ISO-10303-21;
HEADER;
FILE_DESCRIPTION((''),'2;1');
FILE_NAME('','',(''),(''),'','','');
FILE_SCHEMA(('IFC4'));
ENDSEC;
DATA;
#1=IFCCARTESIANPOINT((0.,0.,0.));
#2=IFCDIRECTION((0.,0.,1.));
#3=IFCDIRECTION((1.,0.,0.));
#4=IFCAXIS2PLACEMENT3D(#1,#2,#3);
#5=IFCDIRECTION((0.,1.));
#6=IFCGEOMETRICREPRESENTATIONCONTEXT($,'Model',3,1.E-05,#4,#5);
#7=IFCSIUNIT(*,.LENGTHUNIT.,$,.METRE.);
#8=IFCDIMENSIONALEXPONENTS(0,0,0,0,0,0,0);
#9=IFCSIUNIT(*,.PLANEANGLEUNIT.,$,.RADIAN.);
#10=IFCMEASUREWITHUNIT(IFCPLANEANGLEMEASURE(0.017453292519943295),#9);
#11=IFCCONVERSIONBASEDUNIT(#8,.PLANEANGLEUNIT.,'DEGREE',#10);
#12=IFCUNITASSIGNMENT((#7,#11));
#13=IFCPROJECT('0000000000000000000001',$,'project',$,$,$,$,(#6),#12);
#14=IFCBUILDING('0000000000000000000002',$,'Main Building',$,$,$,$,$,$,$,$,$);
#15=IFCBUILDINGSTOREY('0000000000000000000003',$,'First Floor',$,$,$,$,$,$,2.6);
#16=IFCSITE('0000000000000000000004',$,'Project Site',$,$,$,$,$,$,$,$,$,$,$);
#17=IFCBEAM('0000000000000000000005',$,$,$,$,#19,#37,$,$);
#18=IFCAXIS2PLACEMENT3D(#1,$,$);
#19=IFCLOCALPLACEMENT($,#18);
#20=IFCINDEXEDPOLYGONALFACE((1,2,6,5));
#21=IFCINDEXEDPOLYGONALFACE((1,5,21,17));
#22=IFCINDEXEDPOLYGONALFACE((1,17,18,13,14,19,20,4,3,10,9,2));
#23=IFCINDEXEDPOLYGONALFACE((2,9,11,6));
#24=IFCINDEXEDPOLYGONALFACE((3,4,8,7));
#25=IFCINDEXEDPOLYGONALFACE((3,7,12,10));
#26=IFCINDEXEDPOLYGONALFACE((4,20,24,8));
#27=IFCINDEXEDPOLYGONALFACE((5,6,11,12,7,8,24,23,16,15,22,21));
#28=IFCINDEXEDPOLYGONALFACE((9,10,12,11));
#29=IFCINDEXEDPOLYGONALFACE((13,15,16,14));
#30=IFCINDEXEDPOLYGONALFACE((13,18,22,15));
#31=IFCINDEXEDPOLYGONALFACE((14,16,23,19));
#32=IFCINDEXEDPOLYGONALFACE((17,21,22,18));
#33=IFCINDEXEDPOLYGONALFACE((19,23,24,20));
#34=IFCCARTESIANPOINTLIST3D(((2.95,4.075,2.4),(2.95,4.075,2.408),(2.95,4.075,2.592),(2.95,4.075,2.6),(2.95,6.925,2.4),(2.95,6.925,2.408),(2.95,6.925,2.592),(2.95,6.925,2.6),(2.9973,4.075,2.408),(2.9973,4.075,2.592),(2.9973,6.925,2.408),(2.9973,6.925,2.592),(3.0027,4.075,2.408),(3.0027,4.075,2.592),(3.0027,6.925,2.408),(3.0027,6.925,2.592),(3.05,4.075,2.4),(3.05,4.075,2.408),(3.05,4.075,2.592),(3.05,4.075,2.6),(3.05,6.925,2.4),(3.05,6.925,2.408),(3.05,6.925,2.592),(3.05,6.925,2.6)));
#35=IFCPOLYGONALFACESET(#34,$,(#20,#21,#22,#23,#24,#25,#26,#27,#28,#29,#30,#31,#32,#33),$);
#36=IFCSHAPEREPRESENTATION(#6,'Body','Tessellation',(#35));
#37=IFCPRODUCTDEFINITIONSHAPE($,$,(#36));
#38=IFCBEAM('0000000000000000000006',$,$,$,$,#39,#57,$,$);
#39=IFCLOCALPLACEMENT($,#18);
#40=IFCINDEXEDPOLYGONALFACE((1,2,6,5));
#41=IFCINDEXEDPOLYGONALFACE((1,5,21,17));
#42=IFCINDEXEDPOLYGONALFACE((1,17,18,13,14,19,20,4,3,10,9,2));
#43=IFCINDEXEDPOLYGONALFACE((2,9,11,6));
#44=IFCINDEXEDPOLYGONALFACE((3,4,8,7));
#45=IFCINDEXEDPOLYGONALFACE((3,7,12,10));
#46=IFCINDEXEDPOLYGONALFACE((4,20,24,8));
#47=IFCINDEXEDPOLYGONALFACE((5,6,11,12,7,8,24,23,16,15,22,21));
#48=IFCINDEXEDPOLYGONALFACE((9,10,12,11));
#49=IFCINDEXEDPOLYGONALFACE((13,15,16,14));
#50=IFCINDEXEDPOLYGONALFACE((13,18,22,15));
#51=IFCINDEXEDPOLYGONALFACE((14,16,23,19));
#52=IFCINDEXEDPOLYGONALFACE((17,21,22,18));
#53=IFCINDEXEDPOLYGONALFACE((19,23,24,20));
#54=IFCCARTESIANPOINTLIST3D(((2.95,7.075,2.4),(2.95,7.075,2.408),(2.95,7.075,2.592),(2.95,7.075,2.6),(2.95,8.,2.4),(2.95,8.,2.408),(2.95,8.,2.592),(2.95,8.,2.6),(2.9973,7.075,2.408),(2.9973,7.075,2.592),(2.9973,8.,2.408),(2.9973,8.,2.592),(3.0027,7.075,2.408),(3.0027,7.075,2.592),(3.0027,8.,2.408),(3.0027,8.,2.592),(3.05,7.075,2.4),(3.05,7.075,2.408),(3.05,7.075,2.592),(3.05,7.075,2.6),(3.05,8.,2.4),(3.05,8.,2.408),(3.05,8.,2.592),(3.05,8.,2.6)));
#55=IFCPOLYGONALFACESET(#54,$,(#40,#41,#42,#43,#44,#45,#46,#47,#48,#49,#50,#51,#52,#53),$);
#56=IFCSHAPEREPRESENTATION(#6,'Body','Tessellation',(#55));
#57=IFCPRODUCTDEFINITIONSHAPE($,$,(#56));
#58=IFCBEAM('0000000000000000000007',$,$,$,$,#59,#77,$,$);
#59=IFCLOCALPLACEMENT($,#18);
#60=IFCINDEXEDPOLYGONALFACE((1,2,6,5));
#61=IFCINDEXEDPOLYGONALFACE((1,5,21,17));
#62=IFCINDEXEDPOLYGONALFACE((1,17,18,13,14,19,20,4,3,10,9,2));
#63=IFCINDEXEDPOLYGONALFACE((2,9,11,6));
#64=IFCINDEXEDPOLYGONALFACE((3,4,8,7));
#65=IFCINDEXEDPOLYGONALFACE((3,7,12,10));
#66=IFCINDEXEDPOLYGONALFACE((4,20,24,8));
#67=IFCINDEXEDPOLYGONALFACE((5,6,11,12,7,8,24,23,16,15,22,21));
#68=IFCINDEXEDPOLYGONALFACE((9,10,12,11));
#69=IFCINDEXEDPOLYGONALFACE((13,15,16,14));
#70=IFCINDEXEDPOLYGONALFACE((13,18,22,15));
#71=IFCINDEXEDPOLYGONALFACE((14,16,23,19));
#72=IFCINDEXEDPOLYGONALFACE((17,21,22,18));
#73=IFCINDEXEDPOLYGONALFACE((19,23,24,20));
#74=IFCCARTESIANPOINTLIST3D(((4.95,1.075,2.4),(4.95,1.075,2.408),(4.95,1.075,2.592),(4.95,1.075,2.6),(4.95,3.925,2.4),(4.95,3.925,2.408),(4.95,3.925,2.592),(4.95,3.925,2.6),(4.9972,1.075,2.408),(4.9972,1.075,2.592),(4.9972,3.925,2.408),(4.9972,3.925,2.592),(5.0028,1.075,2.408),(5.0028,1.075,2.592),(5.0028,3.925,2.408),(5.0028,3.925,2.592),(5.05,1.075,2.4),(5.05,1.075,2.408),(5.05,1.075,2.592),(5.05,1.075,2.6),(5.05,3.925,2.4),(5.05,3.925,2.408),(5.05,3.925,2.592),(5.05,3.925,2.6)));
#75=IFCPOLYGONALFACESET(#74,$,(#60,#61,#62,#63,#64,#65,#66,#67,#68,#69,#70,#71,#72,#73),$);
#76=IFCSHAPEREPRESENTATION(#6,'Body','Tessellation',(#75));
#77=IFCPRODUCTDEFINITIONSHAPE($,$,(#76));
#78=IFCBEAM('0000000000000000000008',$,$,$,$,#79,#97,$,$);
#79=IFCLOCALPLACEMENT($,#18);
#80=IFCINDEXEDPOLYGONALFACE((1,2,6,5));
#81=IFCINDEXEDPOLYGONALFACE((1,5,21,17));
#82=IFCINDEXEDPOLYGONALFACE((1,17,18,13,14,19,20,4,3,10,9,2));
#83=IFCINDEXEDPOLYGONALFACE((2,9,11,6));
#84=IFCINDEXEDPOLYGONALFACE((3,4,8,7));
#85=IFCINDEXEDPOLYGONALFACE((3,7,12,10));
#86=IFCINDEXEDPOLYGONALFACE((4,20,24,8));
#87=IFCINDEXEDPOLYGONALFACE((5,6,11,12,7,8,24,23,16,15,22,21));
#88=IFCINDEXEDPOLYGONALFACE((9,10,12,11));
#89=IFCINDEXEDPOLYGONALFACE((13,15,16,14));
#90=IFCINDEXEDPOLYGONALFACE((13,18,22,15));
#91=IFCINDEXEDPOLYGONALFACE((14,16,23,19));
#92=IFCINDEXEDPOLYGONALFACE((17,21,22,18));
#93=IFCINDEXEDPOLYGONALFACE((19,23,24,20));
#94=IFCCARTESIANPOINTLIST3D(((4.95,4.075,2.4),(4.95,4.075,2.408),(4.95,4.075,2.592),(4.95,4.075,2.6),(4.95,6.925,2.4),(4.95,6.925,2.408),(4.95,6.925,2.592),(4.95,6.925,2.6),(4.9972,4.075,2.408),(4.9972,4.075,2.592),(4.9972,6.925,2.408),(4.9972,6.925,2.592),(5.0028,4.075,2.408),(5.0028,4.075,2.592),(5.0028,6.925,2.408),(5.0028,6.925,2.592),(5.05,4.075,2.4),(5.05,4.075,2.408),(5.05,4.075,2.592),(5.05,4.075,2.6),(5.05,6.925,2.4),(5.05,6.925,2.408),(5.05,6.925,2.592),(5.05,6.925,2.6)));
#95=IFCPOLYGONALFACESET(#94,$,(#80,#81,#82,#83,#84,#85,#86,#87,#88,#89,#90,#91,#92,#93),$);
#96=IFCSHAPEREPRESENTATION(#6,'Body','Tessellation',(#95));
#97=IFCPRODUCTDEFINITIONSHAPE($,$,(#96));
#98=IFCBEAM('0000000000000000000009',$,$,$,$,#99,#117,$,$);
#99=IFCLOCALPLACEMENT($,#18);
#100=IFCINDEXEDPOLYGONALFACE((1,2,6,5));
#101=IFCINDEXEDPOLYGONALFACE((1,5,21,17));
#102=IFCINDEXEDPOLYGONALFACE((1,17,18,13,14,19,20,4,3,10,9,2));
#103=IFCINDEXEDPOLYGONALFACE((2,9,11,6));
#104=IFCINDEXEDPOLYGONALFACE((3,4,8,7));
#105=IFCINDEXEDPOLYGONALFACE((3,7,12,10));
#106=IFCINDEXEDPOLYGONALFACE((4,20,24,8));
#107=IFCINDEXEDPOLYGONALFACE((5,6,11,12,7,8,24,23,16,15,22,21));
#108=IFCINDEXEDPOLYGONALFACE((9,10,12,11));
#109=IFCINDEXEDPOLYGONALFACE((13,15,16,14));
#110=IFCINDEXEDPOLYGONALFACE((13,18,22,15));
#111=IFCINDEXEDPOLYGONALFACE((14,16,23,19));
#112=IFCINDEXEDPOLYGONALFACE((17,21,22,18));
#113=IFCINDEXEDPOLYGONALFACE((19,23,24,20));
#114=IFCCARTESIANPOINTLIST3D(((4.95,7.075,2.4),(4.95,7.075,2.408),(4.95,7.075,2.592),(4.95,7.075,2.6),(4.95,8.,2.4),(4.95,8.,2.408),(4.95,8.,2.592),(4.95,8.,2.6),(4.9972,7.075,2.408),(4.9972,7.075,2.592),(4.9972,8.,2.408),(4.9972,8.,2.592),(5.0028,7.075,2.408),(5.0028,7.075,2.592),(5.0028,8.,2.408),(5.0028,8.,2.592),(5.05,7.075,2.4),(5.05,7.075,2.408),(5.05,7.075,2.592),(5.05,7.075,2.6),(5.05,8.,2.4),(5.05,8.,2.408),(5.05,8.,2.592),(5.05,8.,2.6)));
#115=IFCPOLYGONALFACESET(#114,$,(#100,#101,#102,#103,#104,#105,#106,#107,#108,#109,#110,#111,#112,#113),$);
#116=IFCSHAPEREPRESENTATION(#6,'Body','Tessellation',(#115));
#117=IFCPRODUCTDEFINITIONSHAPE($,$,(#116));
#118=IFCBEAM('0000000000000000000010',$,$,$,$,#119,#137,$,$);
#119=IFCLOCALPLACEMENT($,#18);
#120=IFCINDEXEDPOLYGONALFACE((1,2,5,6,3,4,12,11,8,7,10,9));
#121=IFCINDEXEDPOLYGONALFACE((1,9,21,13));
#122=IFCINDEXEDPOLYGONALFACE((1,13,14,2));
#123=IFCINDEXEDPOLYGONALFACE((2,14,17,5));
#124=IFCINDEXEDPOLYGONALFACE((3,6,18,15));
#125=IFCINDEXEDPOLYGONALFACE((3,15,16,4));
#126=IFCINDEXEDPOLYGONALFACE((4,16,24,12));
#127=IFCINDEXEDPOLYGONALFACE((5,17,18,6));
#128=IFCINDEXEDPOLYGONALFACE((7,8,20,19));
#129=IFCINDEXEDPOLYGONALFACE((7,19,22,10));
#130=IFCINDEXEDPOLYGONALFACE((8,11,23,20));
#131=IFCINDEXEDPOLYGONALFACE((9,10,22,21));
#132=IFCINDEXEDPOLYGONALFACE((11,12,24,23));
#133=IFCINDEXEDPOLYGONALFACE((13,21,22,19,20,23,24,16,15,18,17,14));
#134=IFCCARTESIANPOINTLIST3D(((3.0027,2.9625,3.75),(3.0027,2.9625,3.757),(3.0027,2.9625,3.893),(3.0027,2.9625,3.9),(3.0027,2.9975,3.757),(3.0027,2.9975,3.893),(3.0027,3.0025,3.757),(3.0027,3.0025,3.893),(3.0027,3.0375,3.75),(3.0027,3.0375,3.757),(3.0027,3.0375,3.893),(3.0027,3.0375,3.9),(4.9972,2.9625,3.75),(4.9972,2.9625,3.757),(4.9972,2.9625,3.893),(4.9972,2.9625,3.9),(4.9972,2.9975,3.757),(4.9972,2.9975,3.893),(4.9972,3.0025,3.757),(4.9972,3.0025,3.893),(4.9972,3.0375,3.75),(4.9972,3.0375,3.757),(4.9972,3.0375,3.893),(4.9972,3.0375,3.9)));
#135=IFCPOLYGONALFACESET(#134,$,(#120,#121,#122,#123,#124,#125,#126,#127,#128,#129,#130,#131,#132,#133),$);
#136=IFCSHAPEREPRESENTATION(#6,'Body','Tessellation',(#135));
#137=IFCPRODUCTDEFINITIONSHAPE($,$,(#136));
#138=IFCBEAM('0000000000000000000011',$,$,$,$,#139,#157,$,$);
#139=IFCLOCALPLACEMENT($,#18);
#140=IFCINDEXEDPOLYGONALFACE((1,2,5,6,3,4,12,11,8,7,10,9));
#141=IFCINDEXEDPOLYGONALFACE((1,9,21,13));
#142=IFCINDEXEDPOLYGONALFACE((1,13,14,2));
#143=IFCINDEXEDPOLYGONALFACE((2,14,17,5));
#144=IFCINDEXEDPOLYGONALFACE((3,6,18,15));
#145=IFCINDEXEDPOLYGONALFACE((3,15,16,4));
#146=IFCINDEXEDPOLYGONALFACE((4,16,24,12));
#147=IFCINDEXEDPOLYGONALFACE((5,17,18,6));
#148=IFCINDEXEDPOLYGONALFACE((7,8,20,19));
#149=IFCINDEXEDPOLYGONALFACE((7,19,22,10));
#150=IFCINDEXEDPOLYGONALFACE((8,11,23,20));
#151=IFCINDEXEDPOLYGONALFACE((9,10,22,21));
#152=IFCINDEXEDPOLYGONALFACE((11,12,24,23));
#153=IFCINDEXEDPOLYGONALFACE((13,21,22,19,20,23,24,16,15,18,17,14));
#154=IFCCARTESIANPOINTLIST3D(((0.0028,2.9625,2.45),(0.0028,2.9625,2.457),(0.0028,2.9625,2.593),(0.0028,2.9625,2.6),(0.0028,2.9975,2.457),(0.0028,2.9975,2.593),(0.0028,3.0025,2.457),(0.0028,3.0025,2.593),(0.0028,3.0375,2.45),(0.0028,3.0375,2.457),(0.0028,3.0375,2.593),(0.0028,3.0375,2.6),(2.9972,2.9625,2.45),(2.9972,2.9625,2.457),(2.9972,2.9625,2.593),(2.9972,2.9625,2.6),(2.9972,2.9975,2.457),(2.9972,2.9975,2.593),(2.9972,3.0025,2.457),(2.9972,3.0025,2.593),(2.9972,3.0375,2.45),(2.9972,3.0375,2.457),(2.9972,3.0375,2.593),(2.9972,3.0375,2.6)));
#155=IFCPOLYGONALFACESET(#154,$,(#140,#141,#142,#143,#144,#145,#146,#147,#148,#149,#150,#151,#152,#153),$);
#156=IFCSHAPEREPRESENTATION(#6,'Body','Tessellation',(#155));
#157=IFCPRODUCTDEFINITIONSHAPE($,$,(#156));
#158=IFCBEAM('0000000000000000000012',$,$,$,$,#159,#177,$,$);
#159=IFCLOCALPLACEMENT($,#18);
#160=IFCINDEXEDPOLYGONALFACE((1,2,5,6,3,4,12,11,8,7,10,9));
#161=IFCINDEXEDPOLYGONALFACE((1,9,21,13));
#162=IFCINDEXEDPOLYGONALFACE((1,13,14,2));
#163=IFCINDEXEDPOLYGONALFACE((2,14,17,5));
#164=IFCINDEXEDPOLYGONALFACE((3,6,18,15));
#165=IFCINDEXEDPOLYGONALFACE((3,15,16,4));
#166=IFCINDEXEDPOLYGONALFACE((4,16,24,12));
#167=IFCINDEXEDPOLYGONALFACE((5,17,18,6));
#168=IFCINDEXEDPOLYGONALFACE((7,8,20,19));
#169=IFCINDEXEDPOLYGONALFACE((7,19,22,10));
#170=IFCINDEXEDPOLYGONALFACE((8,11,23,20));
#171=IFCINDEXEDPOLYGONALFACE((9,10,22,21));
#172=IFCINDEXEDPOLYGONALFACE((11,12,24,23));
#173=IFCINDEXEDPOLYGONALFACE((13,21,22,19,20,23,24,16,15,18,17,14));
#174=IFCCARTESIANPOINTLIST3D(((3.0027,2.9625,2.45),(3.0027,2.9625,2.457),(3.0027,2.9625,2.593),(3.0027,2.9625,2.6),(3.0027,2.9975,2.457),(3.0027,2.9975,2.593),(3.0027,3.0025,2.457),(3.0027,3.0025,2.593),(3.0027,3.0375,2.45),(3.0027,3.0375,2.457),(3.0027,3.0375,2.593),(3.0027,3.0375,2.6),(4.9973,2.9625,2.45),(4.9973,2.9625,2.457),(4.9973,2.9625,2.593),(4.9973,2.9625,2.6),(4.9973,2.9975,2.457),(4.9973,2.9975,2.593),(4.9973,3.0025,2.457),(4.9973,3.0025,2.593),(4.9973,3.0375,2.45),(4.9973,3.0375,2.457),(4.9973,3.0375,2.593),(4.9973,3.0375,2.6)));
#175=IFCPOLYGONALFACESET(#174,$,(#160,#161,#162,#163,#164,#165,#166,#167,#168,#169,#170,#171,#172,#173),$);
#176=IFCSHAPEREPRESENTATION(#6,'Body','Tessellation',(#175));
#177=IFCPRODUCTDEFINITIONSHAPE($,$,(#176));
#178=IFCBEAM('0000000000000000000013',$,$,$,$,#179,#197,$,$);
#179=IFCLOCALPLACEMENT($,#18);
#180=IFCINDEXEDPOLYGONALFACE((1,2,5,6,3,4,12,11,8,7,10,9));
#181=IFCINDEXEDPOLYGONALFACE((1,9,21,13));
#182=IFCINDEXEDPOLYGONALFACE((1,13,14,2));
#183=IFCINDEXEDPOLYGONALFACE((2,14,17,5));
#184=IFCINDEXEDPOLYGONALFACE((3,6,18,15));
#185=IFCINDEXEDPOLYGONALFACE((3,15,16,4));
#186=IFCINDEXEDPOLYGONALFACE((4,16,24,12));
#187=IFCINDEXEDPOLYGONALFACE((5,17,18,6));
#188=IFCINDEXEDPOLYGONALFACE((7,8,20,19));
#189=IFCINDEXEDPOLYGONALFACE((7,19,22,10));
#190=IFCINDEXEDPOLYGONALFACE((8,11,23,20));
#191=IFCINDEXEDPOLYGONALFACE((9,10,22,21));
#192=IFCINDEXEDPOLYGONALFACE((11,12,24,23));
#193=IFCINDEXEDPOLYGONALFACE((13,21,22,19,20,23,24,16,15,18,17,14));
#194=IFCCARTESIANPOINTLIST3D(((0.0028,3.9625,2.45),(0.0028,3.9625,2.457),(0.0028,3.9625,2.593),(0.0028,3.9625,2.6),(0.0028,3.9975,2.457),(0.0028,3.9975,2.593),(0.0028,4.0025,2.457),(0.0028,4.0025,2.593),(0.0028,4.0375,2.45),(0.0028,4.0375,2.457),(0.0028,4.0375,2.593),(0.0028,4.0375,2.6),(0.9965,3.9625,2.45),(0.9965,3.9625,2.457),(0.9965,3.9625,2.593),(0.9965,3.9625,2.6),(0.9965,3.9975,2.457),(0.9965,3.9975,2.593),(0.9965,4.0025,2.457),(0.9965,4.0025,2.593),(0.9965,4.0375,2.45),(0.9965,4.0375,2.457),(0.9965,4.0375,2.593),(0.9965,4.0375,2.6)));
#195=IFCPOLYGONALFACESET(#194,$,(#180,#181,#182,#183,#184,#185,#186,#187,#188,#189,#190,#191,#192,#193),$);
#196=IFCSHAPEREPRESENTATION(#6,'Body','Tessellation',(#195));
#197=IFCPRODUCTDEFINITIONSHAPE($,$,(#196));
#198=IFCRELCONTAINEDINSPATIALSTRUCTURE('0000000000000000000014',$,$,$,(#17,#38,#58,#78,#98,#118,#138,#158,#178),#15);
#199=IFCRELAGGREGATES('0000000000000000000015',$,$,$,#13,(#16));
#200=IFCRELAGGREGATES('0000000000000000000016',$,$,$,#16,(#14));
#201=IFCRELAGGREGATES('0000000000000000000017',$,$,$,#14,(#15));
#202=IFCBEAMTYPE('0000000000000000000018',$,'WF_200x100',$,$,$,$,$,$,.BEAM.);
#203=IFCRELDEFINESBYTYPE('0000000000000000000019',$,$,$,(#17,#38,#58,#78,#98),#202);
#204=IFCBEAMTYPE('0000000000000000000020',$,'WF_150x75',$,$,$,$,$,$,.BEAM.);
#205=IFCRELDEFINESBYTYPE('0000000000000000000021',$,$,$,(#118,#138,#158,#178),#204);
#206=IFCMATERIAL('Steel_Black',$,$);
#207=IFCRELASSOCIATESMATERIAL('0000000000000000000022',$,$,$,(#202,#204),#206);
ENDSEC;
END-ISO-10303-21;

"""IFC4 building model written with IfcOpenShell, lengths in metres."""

from ifc_helpers import new_model, entity, si_unit, converted_unit, direction, frame, frame_2d, origin_with_axes, origin_2d, place, context, project, spatial, i_section, extrude, material, material_profile, profile_set, type_object, element, save


model = new_model("IFC4")

# Units and contexts
model_context = context("Model", 3, precision=1e-05, world=origin_with_axes(), true_north=direction((0.0, 1.0)))
ifc_project = project(units=[si_unit("LENGTHUNIT", "METRE"), converted_unit("PLANEANGLEUNIT", "DEGREE", entity("IfcPlaneAngleMeasure", 0.017453292519943295), si_unit("PLANEANGLEUNIT", "RADIAN"), dimensions=[0, 0, 0, 0, 0, 0, 0])], contexts=[model_context])

# Site, building, storey
site = spatial("IfcSite", under=ifc_project, Name="Project Site")
building = spatial("IfcBuilding", under=site, Name="Main Building")
storey = spatial("IfcBuildingStorey", under=building, Name="First Floor", Elevation=2.6)

# Shared definitions
ifc_material_1 = material(Name="Steel_Black")

# Beams
ifc_material_profile_1 = material_profile(ifc_material_1, i_section(OverallWidth=0.1, OverallDepth=0.2, WebThickness=0.0055, FlangeThickness=0.008, at=origin_2d()), Name="WF_200x100")
ifc_profile_set_1 = profile_set([ifc_material_profile_1], Name="WF_200x100")
beam_type_1 = type_object("IfcBeamType", Name="WF_200x100", PredefinedType="BEAM", material=ifc_profile_set_1)
beam_1_placement = place(None, frame((3.0, 4.075, 2.4), z_axis=(0.0, 0.0, 1.0), x_axis=(0.0, 1.0, 0.0)))
element("IfcBeam", 1, at=beam_1_placement, inside=storey, type_object=beam_type_1, context=model_context, shape_type="SweptSolid", body=[
    extrude(i_section(OverallWidth=0.1, OverallDepth=0.2, WebThickness=0.0055, FlangeThickness=0.008, at=frame_2d((0.0, 0.1))), frame((0.0, 0.0, 0.0), z_axis=(1.0, 0.0, 0.0), x_axis=(0.0, 1.0, 0.0)), (0.0, 0.0, 1.0), 2.85),
])
beam_2_placement = place(None, frame((3.0, 7.075, 2.4), z_axis=(0.0, 0.0, 1.0), x_axis=(0.0, 1.0, 0.0)))
element("IfcBeam", 2, at=beam_2_placement, inside=storey, type_object=beam_type_1, context=model_context, shape_type="SweptSolid", body=[
    extrude(i_section(OverallWidth=0.1, OverallDepth=0.2, WebThickness=0.0055, FlangeThickness=0.008, at=frame_2d((0.0, 0.1))), frame((0.0, 0.0, 0.0), z_axis=(1.0, 0.0, 0.0), x_axis=(0.0, 1.0, 0.0)), (0.0, 0.0, 1.0), 0.925),
])
for number, where, z_axis, x_axis in (
    (3, (5.0, 1.075, 2.4), (0.0, 0.0, 1.0), (0.0, 1.0, 0.0)),
    (4, (5.0, 4.075, 2.4), (0.0, 0.0, 1.0), (0.0, 1.0, 0.0)),
):
    element("IfcBeam", number, at=place(None, frame(where, z_axis=z_axis, x_axis=x_axis)), inside=storey, type_object=beam_type_1, context=model_context, shape_type="SweptSolid", body=[
        extrude(i_section(OverallWidth=0.1, OverallDepth=0.2, WebThickness=0.0055, FlangeThickness=0.008, at=frame_2d((0.0, 0.1))), frame((0.0, 0.0, 0.0), z_axis=(1.0, 0.0, 0.0), x_axis=(0.0, 1.0, 0.0)), (0.0, 0.0, 1.0), 2.85),
    ])
beam_3_placement = place(None, frame((5.0, 7.075, 2.4), z_axis=(0.0, 0.0, 1.0), x_axis=(0.0, 1.0, 0.0)))
element("IfcBeam", 5, at=beam_3_placement, inside=storey, type_object=beam_type_1, context=model_context, shape_type="SweptSolid", body=[
    extrude(i_section(OverallWidth=0.1, OverallDepth=0.2, WebThickness=0.0055, FlangeThickness=0.008, at=frame_2d((0.0, 0.1))), frame((0.0, 0.0, 0.0), z_axis=(1.0, 0.0, 0.0), x_axis=(0.0, 1.0, 0.0)), (0.0, 0.0, 1.0), 0.925),
])
ifc_material_profile_2 = material_profile(ifc_material_1, i_section(OverallWidth=0.075, OverallDepth=0.15, WebThickness=0.005, FlangeThickness=0.007, at=origin_2d()), Name="WF_150x75")
ifc_profile_set_2 = profile_set([ifc_material_profile_2], Name="WF_150x75")
beam_type_2 = type_object("IfcBeamType", Name="WF_150x75", PredefinedType="BEAM", material=ifc_profile_set_2)
beam_4_placement = place(None, frame((3.0027, 3.0, 3.75), z_axis=(0.0, 0.0, 1.0), x_axis=(1.0, 0.0, 0.0)))
element("IfcBeam", 6, at=beam_4_placement, inside=storey, type_object=beam_type_2, context=model_context, shape_type="SweptSolid", body=[
    extrude(i_section(OverallWidth=0.075, OverallDepth=0.15, WebThickness=0.005, FlangeThickness=0.007, at=frame_2d((0.0, 0.075))), frame((0.0, 0.0, 0.0), z_axis=(1.0, 0.0, 0.0), x_axis=(0.0, 1.0, 0.0)), (0.0, 0.0, 1.0), 1.9945),
])
beam_5_placement = place(None, frame((0.0027, 3.0, 2.45), z_axis=(0.0, 0.0, 1.0), x_axis=(1.0, 0.0, 0.0)))
element("IfcBeam", 7, at=beam_5_placement, inside=storey, type_object=beam_type_2, context=model_context, shape_type="SweptSolid", body=[
    extrude(i_section(OverallWidth=0.075, OverallDepth=0.15, WebThickness=0.005, FlangeThickness=0.007, at=frame_2d((0.0, 0.075))), frame((0.0, 0.0, 0.0), z_axis=(1.0, 0.0, 0.0), x_axis=(0.0, 1.0, 0.0)), (0.0, 0.0, 1.0), 2.9945),
])
beam_6_placement = place(None, frame((3.0027, 3.0, 2.45), z_axis=(0.0, 0.0, 1.0), x_axis=(1.0, 0.0, 0.0)))
element("IfcBeam", 8, at=beam_6_placement, inside=storey, type_object=beam_type_2, context=model_context, shape_type="SweptSolid", body=[
    extrude(i_section(OverallWidth=0.075, OverallDepth=0.15, WebThickness=0.005, FlangeThickness=0.007, at=frame_2d((0.0, 0.075))), frame((0.0, 0.0, 0.0), z_axis=(1.0, 0.0, 0.0), x_axis=(0.0, 1.0, 0.0)), (0.0, 0.0, 1.0), 1.9946),
])
beam_7_placement = place(None, frame((0.0027, 4.0, 2.45), z_axis=(0.0, 0.0, 1.0), x_axis=(1.0, 0.0, 0.0)))
element("IfcBeam", 9, at=beam_7_placement, inside=storey, type_object=beam_type_2, context=model_context, shape_type="SweptSolid", body=[
    extrude(i_section(OverallWidth=0.075, OverallDepth=0.15, WebThickness=0.005, FlangeThickness=0.007, at=frame_2d((0.0, 0.075))), frame((0.0, 0.0, 0.0), z_axis=(1.0, 0.0, 0.0), x_axis=(0.0, 1.0, 0.0)), (0.0, 0.0, 1.0), 0.9938),
])

save(model, "model.ifc")
